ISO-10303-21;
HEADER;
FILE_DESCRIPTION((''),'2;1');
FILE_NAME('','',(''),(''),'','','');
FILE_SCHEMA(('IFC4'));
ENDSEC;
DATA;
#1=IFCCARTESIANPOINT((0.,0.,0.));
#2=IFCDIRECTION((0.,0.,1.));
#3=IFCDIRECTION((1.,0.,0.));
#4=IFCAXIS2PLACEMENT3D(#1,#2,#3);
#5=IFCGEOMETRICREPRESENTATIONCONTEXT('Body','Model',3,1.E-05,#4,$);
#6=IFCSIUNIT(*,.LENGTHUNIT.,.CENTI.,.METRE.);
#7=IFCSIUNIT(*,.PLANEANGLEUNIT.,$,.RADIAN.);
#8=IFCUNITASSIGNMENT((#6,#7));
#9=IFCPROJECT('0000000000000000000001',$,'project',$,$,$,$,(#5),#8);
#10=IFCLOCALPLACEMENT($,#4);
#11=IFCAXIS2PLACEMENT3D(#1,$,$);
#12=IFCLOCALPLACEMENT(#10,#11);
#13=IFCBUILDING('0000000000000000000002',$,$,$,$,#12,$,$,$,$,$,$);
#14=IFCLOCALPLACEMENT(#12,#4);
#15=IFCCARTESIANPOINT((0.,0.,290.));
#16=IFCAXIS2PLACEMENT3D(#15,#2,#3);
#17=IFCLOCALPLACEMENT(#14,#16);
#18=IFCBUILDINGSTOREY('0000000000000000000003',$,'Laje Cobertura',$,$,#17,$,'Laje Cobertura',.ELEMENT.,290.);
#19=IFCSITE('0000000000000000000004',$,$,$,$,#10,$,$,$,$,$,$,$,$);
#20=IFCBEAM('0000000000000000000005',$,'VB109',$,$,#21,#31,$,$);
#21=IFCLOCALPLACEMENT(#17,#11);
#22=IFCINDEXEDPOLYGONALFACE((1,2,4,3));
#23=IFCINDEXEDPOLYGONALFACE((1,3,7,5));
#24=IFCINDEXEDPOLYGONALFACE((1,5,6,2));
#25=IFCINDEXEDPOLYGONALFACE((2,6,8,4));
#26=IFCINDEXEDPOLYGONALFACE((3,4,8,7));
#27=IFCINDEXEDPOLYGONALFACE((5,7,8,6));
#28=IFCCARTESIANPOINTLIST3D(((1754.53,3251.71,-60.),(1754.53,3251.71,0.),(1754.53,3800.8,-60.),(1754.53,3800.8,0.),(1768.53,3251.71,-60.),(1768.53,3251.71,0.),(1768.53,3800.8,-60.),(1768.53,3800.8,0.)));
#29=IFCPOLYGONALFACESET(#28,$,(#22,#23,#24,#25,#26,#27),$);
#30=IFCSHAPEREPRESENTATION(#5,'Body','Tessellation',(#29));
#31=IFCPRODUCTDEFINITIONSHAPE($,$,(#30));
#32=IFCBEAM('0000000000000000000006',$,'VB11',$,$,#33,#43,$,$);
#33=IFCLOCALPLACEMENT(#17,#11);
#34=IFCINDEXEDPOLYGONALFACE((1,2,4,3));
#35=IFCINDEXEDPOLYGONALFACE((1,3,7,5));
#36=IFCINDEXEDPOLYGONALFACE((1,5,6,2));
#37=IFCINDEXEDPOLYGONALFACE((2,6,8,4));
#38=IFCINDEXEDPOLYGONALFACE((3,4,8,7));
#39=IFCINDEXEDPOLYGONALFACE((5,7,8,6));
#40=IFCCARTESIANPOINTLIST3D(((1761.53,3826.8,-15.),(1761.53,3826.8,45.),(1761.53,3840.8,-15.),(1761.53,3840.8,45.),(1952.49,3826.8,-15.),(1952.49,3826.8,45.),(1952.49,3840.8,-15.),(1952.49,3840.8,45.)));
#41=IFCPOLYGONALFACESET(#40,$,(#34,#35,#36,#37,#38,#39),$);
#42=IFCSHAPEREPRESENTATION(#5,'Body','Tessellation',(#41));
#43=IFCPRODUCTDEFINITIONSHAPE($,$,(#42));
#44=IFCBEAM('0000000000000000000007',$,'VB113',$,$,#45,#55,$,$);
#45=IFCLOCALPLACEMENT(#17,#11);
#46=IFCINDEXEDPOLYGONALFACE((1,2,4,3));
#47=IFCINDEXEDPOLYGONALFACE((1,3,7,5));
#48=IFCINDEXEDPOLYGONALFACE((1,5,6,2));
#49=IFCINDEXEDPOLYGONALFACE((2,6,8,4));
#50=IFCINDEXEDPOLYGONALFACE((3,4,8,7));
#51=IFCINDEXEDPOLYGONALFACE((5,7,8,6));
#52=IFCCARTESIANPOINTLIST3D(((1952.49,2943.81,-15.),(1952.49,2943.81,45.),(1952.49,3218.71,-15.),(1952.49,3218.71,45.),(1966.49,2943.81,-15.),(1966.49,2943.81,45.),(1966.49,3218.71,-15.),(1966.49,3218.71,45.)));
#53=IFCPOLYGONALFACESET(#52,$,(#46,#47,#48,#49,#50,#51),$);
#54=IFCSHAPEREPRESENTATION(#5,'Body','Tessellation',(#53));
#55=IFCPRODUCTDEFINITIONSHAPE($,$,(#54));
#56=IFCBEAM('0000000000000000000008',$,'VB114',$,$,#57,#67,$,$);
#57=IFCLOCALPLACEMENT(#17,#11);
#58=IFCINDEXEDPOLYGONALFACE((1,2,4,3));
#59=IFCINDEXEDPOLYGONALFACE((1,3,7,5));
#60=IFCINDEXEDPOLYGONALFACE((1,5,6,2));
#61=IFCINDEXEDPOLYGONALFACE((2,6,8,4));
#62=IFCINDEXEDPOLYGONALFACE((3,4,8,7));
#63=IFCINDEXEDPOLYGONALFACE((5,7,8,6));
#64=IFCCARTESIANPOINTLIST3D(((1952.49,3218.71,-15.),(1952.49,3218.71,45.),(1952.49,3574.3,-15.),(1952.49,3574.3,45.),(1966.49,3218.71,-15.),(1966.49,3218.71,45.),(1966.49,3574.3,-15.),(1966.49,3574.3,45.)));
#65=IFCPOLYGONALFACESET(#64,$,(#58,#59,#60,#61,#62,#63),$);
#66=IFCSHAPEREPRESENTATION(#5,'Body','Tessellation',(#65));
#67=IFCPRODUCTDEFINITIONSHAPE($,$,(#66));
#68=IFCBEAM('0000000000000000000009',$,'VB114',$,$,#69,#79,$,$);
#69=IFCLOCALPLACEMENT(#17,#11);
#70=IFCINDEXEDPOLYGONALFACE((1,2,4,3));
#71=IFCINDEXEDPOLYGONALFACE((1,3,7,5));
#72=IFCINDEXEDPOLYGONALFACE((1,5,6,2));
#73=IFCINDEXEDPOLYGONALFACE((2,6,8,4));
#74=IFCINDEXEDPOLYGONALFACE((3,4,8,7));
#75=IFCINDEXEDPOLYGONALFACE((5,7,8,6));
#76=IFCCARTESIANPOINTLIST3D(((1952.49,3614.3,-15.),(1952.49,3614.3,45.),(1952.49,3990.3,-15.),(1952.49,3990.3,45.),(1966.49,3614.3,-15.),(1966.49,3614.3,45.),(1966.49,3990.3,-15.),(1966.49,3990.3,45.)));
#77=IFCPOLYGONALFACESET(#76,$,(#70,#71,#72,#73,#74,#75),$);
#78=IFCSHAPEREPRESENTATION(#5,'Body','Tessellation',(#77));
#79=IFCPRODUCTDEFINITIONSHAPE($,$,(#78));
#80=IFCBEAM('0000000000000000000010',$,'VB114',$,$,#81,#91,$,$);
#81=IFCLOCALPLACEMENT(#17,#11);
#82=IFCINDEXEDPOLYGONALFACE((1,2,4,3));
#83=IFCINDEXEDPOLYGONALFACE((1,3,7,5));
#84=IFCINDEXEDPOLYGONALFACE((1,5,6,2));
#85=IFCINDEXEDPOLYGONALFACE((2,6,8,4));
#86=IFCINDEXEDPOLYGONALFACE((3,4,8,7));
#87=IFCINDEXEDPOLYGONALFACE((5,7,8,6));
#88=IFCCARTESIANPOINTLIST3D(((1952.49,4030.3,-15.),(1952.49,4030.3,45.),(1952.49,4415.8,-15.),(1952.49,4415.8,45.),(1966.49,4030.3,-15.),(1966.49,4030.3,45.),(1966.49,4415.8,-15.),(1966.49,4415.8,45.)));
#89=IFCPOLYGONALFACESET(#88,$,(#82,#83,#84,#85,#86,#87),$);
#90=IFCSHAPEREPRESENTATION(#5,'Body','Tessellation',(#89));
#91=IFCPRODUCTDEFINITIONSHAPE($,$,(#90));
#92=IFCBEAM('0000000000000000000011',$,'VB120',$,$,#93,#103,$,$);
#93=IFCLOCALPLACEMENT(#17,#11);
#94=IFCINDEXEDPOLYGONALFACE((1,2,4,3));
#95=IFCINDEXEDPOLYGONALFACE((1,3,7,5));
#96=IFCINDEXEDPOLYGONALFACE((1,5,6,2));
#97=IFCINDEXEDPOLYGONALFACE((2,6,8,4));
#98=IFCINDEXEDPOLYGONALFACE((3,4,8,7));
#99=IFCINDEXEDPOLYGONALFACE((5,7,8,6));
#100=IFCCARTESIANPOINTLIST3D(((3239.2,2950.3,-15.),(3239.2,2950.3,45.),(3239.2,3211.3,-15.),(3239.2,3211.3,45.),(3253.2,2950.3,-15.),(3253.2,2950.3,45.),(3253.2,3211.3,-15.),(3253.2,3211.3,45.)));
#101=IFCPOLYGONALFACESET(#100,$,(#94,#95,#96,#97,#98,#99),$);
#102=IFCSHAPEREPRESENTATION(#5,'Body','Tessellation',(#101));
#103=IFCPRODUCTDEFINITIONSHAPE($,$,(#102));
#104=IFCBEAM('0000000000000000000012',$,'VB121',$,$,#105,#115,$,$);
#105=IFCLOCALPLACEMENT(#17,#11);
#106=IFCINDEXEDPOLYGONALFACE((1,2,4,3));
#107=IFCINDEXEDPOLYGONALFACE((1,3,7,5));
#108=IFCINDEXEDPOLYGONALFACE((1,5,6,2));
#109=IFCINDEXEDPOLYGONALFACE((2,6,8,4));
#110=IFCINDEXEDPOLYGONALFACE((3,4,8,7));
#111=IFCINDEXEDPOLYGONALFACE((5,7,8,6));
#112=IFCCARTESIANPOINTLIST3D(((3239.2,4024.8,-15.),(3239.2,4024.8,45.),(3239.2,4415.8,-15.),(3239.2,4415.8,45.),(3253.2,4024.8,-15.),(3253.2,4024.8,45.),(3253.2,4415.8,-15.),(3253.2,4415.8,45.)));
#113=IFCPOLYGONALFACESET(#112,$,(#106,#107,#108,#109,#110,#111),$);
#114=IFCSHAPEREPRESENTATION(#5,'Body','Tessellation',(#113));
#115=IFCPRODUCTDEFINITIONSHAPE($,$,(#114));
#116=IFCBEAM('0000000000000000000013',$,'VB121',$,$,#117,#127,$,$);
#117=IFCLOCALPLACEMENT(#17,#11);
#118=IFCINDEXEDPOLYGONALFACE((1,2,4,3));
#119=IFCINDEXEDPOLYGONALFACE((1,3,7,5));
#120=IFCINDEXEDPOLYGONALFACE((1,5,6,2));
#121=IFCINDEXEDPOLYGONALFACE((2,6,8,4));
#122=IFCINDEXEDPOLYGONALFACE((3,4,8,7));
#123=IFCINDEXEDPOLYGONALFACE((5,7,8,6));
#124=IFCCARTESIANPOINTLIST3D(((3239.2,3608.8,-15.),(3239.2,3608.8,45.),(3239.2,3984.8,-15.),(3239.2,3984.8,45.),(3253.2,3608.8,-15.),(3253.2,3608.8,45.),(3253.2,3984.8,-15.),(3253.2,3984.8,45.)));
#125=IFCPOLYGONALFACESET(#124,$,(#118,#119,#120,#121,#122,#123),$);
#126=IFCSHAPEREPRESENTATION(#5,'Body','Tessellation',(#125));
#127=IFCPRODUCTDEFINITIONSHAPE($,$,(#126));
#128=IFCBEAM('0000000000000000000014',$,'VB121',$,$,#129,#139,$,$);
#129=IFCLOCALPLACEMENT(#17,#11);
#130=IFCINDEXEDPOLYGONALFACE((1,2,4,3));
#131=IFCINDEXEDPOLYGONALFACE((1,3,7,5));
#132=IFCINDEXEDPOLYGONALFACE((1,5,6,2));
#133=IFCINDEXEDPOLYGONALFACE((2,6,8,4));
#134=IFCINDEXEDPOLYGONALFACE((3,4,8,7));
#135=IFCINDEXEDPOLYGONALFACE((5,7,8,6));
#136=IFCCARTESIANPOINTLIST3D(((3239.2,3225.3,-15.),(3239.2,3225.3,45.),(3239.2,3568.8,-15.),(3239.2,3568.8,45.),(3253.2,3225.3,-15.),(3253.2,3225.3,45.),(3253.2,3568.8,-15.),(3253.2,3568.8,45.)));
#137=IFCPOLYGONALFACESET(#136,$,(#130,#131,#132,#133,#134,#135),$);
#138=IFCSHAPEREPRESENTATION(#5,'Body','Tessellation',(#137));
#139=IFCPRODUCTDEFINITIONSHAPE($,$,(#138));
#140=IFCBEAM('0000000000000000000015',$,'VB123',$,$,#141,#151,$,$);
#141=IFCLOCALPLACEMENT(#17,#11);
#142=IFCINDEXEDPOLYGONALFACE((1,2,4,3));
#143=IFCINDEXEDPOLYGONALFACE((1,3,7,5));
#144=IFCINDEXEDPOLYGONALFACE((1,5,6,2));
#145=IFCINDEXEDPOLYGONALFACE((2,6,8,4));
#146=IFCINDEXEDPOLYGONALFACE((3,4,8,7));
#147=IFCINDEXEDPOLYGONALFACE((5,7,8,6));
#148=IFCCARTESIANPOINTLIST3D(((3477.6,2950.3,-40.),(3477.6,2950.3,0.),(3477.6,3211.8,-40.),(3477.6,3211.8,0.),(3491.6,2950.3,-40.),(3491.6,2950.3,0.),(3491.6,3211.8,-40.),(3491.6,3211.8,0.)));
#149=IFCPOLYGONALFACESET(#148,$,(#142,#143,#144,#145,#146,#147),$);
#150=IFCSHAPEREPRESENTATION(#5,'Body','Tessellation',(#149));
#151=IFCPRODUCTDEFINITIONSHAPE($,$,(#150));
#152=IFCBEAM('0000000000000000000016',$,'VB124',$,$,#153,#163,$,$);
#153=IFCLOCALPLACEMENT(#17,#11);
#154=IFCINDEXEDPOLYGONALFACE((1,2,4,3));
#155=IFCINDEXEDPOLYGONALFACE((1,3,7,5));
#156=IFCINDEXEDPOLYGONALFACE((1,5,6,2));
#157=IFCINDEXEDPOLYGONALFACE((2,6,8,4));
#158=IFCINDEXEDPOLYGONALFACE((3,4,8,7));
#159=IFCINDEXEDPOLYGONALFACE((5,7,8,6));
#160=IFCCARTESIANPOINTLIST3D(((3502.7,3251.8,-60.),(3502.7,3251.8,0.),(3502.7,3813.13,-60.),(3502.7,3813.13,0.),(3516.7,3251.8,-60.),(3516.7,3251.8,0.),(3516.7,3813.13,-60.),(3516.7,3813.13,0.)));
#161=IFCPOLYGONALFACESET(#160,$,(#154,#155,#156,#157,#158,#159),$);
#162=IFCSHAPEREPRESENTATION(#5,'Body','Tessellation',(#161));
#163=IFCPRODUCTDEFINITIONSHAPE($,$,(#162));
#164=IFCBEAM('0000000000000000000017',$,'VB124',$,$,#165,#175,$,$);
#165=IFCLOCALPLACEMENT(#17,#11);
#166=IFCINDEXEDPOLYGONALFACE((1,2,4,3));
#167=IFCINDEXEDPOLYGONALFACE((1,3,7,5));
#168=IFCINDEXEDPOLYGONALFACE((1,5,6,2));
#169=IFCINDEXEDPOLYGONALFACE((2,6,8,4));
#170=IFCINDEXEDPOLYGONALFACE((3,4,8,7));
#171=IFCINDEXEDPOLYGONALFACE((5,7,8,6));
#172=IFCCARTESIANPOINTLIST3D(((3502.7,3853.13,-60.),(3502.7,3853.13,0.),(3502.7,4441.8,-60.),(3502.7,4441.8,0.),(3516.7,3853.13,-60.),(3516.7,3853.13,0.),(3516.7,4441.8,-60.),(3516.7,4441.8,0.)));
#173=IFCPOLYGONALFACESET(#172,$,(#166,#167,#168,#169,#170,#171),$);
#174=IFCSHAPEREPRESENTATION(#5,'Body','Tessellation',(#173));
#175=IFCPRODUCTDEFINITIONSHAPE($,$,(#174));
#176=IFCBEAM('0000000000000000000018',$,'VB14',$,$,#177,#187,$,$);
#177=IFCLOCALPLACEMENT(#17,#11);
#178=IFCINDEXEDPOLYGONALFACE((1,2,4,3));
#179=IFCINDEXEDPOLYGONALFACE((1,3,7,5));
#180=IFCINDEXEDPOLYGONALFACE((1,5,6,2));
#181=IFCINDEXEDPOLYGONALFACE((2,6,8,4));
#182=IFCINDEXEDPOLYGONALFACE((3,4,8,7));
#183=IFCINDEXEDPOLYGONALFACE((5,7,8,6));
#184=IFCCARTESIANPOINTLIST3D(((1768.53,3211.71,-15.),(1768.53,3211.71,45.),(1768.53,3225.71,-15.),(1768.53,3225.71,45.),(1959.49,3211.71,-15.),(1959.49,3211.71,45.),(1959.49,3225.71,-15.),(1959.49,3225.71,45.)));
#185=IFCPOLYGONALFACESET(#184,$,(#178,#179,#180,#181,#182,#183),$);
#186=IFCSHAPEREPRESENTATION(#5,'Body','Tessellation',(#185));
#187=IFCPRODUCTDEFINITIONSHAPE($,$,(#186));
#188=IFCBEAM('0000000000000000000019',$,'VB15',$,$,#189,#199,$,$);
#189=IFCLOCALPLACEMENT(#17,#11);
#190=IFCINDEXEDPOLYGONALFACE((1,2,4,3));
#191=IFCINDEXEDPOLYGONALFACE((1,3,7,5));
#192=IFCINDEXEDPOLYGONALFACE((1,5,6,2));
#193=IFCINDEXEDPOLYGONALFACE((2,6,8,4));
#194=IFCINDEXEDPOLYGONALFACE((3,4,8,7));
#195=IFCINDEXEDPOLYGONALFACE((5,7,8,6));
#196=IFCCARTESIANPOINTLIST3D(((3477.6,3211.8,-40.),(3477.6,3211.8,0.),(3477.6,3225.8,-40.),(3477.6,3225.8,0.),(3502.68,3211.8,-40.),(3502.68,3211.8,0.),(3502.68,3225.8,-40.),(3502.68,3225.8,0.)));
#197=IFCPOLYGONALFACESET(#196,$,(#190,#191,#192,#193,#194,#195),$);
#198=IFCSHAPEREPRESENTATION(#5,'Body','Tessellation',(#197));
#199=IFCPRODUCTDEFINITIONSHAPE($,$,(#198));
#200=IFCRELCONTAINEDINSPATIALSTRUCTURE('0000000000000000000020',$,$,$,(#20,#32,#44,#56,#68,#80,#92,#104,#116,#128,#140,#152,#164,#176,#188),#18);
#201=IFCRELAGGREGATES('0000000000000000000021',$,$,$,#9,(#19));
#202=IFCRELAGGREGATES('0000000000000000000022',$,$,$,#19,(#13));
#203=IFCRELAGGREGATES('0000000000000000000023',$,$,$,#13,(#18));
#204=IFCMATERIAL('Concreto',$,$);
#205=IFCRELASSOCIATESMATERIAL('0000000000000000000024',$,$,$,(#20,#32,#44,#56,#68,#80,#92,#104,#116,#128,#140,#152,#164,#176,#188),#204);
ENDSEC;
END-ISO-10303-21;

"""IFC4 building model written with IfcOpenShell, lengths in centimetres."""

from ifc_helpers import new_model, si_unit, frame, origin, origin_with_axes, origin_2d_with_axis, place, context, project, spatial, rectangle, extrude, material, element, save


model = new_model("IFC4")

# Units and contexts
model_context = context("Model", 3, precision=1e-05, world=origin_with_axes(), identifier="Body")
ifc_project = project(units=[si_unit("LENGTHUNIT", "METRE", prefix="CENTI"), si_unit("PLANEANGLEUNIT", "RADIAN")], contexts=[model_context])

# Site, building, storey
site_placement = place(None, origin_with_axes())
site = spatial("IfcSite", under=ifc_project, at=site_placement)
building_placement = place(site_placement, origin())
building = spatial("IfcBuilding", under=site, at=building_placement)
placement = place(building_placement, origin_with_axes())
storey_placement = place(placement, frame((0.0, 0.0, 290.0), z_axis=(0.0, 0.0, 1.0), x_axis=(1.0, 0.0, 0.0)))
storey = spatial("IfcBuildingStorey", under=building, at=storey_placement, Name="Laje Cobertura", LongName="Laje Cobertura", CompositionType="ELEMENT", Elevation=290.0)

# Shared definitions
ifc_material = material(Name="Concreto")

# Beams
beam_1_placement = place(storey_placement, frame((1761.53, 3526.26, 0.0), z_axis=(0.0, 0.0, 1.0), x_axis=(1.0, 0.0, 0.0)))
element("IfcBeam", 1, at=beam_1_placement, inside=storey, material=ifc_material, Name="VB109", context=model_context, shape_type="SolidModel", body=[
    extrude(rectangle(XDim=14.0, YDim=60.0, at=origin_2d_with_axis()), frame((0.0, -274.55, -30.0), z_axis=(0.0, 1.0, 0.0), x_axis=(-1.0, 0.0, 0.0)), (0.0, 0.0, 1.0), 549.09),
])
beam_2_placement = place(storey_placement, frame((1857.01, 3833.8, 45.0), z_axis=(0.0, 0.0, 1.0), x_axis=(1.0, 0.0, 0.0)))
element("IfcBeam", 2, at=beam_2_placement, inside=storey, material=ifc_material, Name="VB11", context=model_context, shape_type="SolidModel", body=[
    extrude(rectangle(XDim=14.0, YDim=60.0, at=origin_2d_with_axis()), frame((-95.48, 0.0, -30.0), z_axis=(1.0, 0.0, 0.0), x_axis=(0.0, 1.0, 0.0)), (0.0, 0.0, 1.0), 190.96),
])
beam_3_placement = place(storey_placement, frame((1959.49, 3081.26, 45.0), z_axis=(0.0, 0.0, 1.0), x_axis=(1.0, 0.0, 0.0)))
element("IfcBeam", 3, at=beam_3_placement, inside=storey, material=ifc_material, Name="VB113", context=model_context, shape_type="SolidModel", body=[
    extrude(rectangle(XDim=14.0, YDim=60.0, at=origin_2d_with_axis()), frame((0.0, -137.45, -30.0), z_axis=(0.0, 1.0, 0.0), x_axis=(1.0, 0.0, 0.0)), (0.0, 0.0, 1.0), 274.9),
])
beam_4_placement = place(storey_placement, frame((1959.49, 3396.51, 45.0), z_axis=(0.0, 0.0, 1.0), x_axis=(1.0, 0.0, 0.0)))
element("IfcBeam", 4, at=beam_4_placement, inside=storey, material=ifc_material, Name="VB114", context=model_context, shape_type="SolidModel", body=[
    extrude(rectangle(XDim=14.0, YDim=60.0, at=origin_2d_with_axis()), frame((0.0, -177.79, -30.0), z_axis=(0.0, 1.0, 0.0), x_axis=(-1.0, 0.0, 0.0)), (0.0, 0.0, 1.0), 355.59),
])
beam_5_placement = place(storey_placement, frame((1959.49, 3802.3, 45.0), z_axis=(0.0, 0.0, 1.0), x_axis=(1.0, 0.0, 0.0)))
element("IfcBeam", 5, at=beam_5_placement, inside=storey, material=ifc_material, Name="VB114", context=model_context, shape_type="SolidModel", body=[
    extrude(rectangle(XDim=14.0, YDim=60.0, at=origin_2d_with_axis()), frame((0.0, -188.0, -30.0), z_axis=(0.0, 1.0, 0.0), x_axis=(-1.0, 0.0, 0.0)), (0.0, 0.0, 1.0), 376.0),
])
beam_6_placement = place(storey_placement, frame((1959.49, 4223.05, 45.0), z_axis=(0.0, 0.0, 1.0), x_axis=(1.0, 0.0, 0.0)))
element("IfcBeam", 6, at=beam_6_placement, inside=storey, material=ifc_material, Name="VB114", context=model_context, shape_type="SolidModel", body=[
    extrude(rectangle(XDim=14.0, YDim=60.0, at=origin_2d_with_axis()), frame((0.0, -192.75, -30.0), z_axis=(0.0, 1.0, 0.0), x_axis=(-1.0, 0.0, 0.0)), (0.0, 0.0, 1.0), 385.5),
])
beam_7_placement = place(storey_placement, frame((3246.2, 3080.8, 45.0), z_axis=(0.0, 0.0, 1.0), x_axis=(1.0, 0.0, 0.0)))
element("IfcBeam", 7, at=beam_7_placement, inside=storey, material=ifc_material, Name="VB120", context=model_context, shape_type="SolidModel", body=[
    extrude(rectangle(XDim=14.0, YDim=60.0, at=origin_2d_with_axis()), frame((0.0, -130.5, -30.0), z_axis=(0.0, 1.0, 0.0), x_axis=(1.0, 0.0, 0.0)), (0.0, 0.0, 1.0), 261.0),
])
beam_8_placement = place(storey_placement, frame((3246.2, 4220.3, 45.0), z_axis=(0.0, 0.0, 1.0), x_axis=(1.0, 0.0, 0.0)))
element("IfcBeam", 8, at=beam_8_placement, inside=storey, material=ifc_material, Name="VB121", context=model_context, shape_type="SolidModel", body=[
    extrude(rectangle(XDim=14.0, YDim=60.0, at=origin_2d_with_axis()), frame((0.0, -195.5, -30.0), z_axis=(0.0, 1.0, 0.0), x_axis=(1.0, 0.0, 0.0)), (0.0, 0.0, 1.0), 391.0),
])
beam_9_placement = place(storey_placement, frame((3246.2, 3796.8, 45.0), z_axis=(0.0, 0.0, 1.0), x_axis=(1.0, 0.0, 0.0)))
element("IfcBeam", 9, at=beam_9_placement, inside=storey, material=ifc_material, Name="VB121", context=model_context, shape_type="SolidModel", body=[
    extrude(rectangle(XDim=14.0, YDim=60.0, at=origin_2d_with_axis()), frame((0.0, -188.0, -30.0), z_axis=(0.0, 1.0, 0.0), x_axis=(1.0, 0.0, 0.0)), (0.0, 0.0, 1.0), 376.0),
])
beam_10_placement = place(storey_placement, frame((3246.2, 3397.05, 45.0), z_axis=(0.0, 0.0, 1.0), x_axis=(1.0, 0.0, 0.0)))
element("IfcBeam", 10, at=beam_10_placement, inside=storey, material=ifc_material, Name="VB121", context=model_context, shape_type="SolidModel", body=[
    extrude(rectangle(XDim=14.0, YDim=60.0, at=origin_2d_with_axis()), frame((0.0, -171.75, -30.0), z_axis=(0.0, 1.0, 0.0), x_axis=(1.0, 0.0, 0.0)), (0.0, 0.0, 1.0), 343.5),
])
beam_11_placement = place(storey_placement, frame((3484.6, 3081.05, 0.0), z_axis=(0.0, 0.0, 1.0), x_axis=(1.0, 0.0, 0.0)))
element("IfcBeam", 11, at=beam_11_placement, inside=storey, material=ifc_material, Name="VB123", context=model_context, shape_type="SolidModel", body=[
    extrude(rectangle(XDim=14.0, YDim=40.0, at=origin_2d_with_axis()), frame((0.0, -130.75, -20.0), z_axis=(0.0, 1.0, 0.0), x_axis=(1.0, 0.0, 0.0)), (0.0, 0.0, 1.0), 261.5),
])
beam_12_placement = place(storey_placement, frame((3509.7, 3532.47, 0.0), z_axis=(0.0, 0.0, 1.0), x_axis=(1.0, 0.0, 0.0)))
element("IfcBeam", 12, at=beam_12_placement, inside=storey, material=ifc_material, Name="VB124", context=model_context, shape_type="SolidModel", body=[
    extrude(rectangle(XDim=14.0, YDim=60.0, at=origin_2d_with_axis()), frame((0.0, -280.67, -30.0), z_axis=(0.0, 1.0, 0.0), x_axis=(1.0, 0.0, 0.0)), (0.0, 0.0, 1.0), 561.33),
])
beam_13_placement = place(storey_placement, frame((3509.7, 4147.47, 0.0), z_axis=(0.0, 0.0, 1.0), x_axis=(1.0, 0.0, 0.0)))
element("IfcBeam", 13, at=beam_13_placement, inside=storey, material=ifc_material, Name="VB124", context=model_context, shape_type="SolidModel", body=[
    extrude(rectangle(XDim=14.0, YDim=60.0, at=origin_2d_with_axis()), frame((0.0, -294.33, -30.0), z_axis=(0.0, 1.0, 0.0), x_axis=(1.0, 0.0, 0.0)), (0.0, 0.0, 1.0), 588.67),
])
beam_14_placement = place(storey_placement, frame((1864.01, 3218.71, 45.0), z_axis=(0.0, 0.0, 1.0), x_axis=(1.0, 0.0, 0.0)))
element("IfcBeam", 14, at=beam_14_placement, inside=storey, material=ifc_material, Name="VB14", context=model_context, shape_type="SolidModel", body=[
    extrude(rectangle(XDim=14.0, YDim=60.0, at=origin_2d_with_axis()), frame((-95.48, 0.0, -30.0), z_axis=(1.0, 0.0, 0.0), x_axis=(0.0, 1.0, 0.0)), (0.0, 0.0, 1.0), 190.96),
])
beam_15_placement = place(storey_placement, frame((3490.14, 3218.8, 0.0), z_axis=(0.0, 0.0, 1.0), x_axis=(1.0, 0.0, 0.0)))
element("IfcBeam", 15, at=beam_15_placement, inside=storey, material=ifc_material, Name="VB15", context=model_context, shape_type="SolidModel", body=[
    extrude(rectangle(XDim=14.0, YDim=40.0, at=origin_2d_with_axis()), frame((-12.54, 0.0, -20.0), z_axis=(1.0, 0.0, 0.0), x_axis=(0.0, 1.0, 0.0)), (0.0, 0.0, 1.0), 25.08),
])

save(model, "model.ifc")
